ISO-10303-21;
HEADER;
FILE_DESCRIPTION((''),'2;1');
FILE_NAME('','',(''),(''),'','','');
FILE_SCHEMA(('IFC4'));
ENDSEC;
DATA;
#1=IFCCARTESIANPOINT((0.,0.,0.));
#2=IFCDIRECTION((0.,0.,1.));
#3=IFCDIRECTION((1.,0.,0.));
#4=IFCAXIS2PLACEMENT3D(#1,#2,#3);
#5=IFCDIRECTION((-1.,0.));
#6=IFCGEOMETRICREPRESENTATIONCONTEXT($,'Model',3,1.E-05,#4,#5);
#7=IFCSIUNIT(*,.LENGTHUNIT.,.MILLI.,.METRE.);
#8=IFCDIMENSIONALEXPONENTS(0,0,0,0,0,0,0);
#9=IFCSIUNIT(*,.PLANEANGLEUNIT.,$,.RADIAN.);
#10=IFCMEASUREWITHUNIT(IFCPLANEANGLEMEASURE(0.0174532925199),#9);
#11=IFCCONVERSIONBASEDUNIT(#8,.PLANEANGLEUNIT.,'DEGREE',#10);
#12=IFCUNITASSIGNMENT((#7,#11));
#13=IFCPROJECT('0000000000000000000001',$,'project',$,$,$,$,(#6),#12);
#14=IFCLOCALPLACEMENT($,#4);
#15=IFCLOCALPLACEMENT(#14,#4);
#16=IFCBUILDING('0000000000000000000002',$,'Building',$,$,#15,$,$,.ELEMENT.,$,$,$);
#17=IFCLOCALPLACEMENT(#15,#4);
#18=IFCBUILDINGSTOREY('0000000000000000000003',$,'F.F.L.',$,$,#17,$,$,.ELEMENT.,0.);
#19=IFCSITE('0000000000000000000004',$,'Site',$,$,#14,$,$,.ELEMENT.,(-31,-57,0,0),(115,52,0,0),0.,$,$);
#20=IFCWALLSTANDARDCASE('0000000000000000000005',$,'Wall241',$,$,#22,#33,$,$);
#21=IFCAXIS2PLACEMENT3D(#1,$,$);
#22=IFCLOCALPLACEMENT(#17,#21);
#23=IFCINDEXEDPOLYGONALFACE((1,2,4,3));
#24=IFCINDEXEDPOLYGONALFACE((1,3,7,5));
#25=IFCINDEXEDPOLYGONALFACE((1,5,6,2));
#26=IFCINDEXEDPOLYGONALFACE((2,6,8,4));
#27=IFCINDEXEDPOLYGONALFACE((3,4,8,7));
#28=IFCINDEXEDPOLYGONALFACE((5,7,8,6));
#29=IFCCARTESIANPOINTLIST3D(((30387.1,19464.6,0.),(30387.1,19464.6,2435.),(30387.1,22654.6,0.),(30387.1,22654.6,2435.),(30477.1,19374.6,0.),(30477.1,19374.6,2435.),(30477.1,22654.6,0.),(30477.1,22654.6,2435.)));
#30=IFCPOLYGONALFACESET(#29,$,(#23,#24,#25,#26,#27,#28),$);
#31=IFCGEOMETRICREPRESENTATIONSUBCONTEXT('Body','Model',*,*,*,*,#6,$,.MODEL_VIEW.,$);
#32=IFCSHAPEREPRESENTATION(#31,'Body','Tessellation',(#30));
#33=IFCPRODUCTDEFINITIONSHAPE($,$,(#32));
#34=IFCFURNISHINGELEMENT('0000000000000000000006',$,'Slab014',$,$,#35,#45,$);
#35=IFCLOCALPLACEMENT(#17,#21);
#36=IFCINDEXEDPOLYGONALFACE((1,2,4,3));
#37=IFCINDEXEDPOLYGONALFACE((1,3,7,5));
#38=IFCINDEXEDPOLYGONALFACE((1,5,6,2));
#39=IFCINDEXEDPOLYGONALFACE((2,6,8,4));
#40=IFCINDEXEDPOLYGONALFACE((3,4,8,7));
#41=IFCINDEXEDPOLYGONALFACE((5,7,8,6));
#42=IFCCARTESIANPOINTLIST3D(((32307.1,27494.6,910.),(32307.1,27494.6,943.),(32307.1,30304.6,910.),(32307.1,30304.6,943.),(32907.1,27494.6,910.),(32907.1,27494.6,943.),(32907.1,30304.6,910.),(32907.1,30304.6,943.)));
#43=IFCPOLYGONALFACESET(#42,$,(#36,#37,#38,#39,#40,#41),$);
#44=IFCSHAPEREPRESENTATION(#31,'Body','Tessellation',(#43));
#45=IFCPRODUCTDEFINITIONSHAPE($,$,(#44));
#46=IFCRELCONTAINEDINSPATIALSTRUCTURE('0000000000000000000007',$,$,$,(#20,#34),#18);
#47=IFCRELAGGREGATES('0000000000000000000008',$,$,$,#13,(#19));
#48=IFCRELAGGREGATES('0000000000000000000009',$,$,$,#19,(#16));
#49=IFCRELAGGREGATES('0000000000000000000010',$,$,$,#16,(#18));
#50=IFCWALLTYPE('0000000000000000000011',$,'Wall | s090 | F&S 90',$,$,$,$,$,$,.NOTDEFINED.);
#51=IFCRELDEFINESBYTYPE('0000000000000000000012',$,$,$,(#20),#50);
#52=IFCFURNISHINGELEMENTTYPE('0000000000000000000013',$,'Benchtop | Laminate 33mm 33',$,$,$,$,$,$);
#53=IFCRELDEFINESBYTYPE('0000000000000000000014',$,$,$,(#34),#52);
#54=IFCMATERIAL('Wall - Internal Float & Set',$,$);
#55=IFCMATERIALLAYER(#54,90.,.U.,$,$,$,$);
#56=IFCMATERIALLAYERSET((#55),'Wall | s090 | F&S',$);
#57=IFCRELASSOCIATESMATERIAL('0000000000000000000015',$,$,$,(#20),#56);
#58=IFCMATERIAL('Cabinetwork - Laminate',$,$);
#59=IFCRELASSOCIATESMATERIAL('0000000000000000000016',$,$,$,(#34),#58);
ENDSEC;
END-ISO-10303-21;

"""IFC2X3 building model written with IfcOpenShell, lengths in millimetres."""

from ifc_helpers import new_model, entity, si_unit, converted_unit, direction, frame, origin_with_axes, place, context, subcontext, project, spatial, polyline, outline, extrude, material, layer, layer_set, layer_usage, type_object, element, save


model = new_model("IFC2X3")

# Units and contexts
model_context = context("Model", 3, precision=1e-05, world=origin_with_axes(), true_north=direction((-1.0, 0.0)))
body_context = subcontext(model_context, "Body", "Model", "MODEL_VIEW")
ifc_project = project(units=[si_unit("LENGTHUNIT", "METRE", prefix="MILLI"), converted_unit("PLANEANGLEUNIT", "DEGREE", entity("IfcPlaneAngleMeasure", 0.0174532925199), si_unit("PLANEANGLEUNIT", "RADIAN"), dimensions=[0, 0, 0, 0, 0, 0, 0])], contexts=[model_context])

# Site, building, storey
site_placement = place(None, origin_with_axes())
site = spatial("IfcSite", under=ifc_project, at=site_placement, Name="Site", CompositionType="ELEMENT", RefLatitude=(-31, -57, 0, 0), RefLongitude=(115, 52, 0, 0), RefElevation=0.0)
building_placement = place(site_placement, origin_with_axes())
building = spatial("IfcBuilding", under=site, at=building_placement, Name="Building", CompositionType="ELEMENT")
storey_placement = place(building_placement, origin_with_axes())
storey = spatial("IfcBuildingStorey", under=building, at=storey_placement, Name="F.F.L.", CompositionType="ELEMENT", Elevation=0.0)

# Shared definitions
ifc_material_1 = material(Name="Wall - Internal Float & Set")
ifc_layer = layer(ifc_material_1, 90.0, ventilated="UNKNOWN")
ifc_layer_set = layer_set([ifc_layer], Name="Wall | s090 | F&S")
wall_type = type_object("IfcWallType", Name="Wall | s090 | F&S 90", PredefinedType="NOTDEFINED")

# Wall
ifc_layer_usage_1 = layer_usage(ifc_layer_set, "AXIS2", "POSITIVE", -90.0)
wall_1_placement = place(storey_placement, frame((30477.1, 22654.6, 0.0), z_axis=(0.0, 0.0, 1.0), x_axis=(0.0, -1.0, 0.0)))
element("IfcWallStandardCase", 1, at=wall_1_placement, inside=storey, type_object=wall_type, material=ifc_layer_usage_1, Name="Wall241", context=body_context, shape_type="SweptSolid", body=[
    extrude(outline(polyline([(0.0, -90.0), (3190.0, -90.0), (3280.0, 0.0), (0.0, 0.0), (0.0, -90.0)])), origin_with_axes(), (0.0, 0.0, 1.0), 2435.0),
])

# Furnishing element
ifc_material_2 = material(Name="Cabinetwork - Laminate")
furnishing_element_type = type_object("IfcFurnishingElementType", Name="Benchtop | Laminate 33mm 33")
furnishing_placement = place(storey_placement, frame((32307.1, 30304.6, 943.0), z_axis=(0.0, 0.0, 1.0), x_axis=(1.0, 0.0, 0.0)))
element("IfcFurnishingElement", 2, at=furnishing_placement, inside=storey, type_object=furnishing_element_type, material=ifc_material_2, Name="Slab014", context=body_context, shape_type="SweptSolid", body=[
    extrude(outline(polyline([(0.0, 0.0), (0.0, -2810.0), (600.0, -2810.0), (600.0, 0.0), (0.0, 0.0)])), frame((0.0, 0.0, -33.0), z_axis=(0.0, 0.0, 1.0), x_axis=(1.0, 0.0, 0.0)), (0.0, 0.0, 1.0), 33.0),
])

save(model, "model.ifc")
